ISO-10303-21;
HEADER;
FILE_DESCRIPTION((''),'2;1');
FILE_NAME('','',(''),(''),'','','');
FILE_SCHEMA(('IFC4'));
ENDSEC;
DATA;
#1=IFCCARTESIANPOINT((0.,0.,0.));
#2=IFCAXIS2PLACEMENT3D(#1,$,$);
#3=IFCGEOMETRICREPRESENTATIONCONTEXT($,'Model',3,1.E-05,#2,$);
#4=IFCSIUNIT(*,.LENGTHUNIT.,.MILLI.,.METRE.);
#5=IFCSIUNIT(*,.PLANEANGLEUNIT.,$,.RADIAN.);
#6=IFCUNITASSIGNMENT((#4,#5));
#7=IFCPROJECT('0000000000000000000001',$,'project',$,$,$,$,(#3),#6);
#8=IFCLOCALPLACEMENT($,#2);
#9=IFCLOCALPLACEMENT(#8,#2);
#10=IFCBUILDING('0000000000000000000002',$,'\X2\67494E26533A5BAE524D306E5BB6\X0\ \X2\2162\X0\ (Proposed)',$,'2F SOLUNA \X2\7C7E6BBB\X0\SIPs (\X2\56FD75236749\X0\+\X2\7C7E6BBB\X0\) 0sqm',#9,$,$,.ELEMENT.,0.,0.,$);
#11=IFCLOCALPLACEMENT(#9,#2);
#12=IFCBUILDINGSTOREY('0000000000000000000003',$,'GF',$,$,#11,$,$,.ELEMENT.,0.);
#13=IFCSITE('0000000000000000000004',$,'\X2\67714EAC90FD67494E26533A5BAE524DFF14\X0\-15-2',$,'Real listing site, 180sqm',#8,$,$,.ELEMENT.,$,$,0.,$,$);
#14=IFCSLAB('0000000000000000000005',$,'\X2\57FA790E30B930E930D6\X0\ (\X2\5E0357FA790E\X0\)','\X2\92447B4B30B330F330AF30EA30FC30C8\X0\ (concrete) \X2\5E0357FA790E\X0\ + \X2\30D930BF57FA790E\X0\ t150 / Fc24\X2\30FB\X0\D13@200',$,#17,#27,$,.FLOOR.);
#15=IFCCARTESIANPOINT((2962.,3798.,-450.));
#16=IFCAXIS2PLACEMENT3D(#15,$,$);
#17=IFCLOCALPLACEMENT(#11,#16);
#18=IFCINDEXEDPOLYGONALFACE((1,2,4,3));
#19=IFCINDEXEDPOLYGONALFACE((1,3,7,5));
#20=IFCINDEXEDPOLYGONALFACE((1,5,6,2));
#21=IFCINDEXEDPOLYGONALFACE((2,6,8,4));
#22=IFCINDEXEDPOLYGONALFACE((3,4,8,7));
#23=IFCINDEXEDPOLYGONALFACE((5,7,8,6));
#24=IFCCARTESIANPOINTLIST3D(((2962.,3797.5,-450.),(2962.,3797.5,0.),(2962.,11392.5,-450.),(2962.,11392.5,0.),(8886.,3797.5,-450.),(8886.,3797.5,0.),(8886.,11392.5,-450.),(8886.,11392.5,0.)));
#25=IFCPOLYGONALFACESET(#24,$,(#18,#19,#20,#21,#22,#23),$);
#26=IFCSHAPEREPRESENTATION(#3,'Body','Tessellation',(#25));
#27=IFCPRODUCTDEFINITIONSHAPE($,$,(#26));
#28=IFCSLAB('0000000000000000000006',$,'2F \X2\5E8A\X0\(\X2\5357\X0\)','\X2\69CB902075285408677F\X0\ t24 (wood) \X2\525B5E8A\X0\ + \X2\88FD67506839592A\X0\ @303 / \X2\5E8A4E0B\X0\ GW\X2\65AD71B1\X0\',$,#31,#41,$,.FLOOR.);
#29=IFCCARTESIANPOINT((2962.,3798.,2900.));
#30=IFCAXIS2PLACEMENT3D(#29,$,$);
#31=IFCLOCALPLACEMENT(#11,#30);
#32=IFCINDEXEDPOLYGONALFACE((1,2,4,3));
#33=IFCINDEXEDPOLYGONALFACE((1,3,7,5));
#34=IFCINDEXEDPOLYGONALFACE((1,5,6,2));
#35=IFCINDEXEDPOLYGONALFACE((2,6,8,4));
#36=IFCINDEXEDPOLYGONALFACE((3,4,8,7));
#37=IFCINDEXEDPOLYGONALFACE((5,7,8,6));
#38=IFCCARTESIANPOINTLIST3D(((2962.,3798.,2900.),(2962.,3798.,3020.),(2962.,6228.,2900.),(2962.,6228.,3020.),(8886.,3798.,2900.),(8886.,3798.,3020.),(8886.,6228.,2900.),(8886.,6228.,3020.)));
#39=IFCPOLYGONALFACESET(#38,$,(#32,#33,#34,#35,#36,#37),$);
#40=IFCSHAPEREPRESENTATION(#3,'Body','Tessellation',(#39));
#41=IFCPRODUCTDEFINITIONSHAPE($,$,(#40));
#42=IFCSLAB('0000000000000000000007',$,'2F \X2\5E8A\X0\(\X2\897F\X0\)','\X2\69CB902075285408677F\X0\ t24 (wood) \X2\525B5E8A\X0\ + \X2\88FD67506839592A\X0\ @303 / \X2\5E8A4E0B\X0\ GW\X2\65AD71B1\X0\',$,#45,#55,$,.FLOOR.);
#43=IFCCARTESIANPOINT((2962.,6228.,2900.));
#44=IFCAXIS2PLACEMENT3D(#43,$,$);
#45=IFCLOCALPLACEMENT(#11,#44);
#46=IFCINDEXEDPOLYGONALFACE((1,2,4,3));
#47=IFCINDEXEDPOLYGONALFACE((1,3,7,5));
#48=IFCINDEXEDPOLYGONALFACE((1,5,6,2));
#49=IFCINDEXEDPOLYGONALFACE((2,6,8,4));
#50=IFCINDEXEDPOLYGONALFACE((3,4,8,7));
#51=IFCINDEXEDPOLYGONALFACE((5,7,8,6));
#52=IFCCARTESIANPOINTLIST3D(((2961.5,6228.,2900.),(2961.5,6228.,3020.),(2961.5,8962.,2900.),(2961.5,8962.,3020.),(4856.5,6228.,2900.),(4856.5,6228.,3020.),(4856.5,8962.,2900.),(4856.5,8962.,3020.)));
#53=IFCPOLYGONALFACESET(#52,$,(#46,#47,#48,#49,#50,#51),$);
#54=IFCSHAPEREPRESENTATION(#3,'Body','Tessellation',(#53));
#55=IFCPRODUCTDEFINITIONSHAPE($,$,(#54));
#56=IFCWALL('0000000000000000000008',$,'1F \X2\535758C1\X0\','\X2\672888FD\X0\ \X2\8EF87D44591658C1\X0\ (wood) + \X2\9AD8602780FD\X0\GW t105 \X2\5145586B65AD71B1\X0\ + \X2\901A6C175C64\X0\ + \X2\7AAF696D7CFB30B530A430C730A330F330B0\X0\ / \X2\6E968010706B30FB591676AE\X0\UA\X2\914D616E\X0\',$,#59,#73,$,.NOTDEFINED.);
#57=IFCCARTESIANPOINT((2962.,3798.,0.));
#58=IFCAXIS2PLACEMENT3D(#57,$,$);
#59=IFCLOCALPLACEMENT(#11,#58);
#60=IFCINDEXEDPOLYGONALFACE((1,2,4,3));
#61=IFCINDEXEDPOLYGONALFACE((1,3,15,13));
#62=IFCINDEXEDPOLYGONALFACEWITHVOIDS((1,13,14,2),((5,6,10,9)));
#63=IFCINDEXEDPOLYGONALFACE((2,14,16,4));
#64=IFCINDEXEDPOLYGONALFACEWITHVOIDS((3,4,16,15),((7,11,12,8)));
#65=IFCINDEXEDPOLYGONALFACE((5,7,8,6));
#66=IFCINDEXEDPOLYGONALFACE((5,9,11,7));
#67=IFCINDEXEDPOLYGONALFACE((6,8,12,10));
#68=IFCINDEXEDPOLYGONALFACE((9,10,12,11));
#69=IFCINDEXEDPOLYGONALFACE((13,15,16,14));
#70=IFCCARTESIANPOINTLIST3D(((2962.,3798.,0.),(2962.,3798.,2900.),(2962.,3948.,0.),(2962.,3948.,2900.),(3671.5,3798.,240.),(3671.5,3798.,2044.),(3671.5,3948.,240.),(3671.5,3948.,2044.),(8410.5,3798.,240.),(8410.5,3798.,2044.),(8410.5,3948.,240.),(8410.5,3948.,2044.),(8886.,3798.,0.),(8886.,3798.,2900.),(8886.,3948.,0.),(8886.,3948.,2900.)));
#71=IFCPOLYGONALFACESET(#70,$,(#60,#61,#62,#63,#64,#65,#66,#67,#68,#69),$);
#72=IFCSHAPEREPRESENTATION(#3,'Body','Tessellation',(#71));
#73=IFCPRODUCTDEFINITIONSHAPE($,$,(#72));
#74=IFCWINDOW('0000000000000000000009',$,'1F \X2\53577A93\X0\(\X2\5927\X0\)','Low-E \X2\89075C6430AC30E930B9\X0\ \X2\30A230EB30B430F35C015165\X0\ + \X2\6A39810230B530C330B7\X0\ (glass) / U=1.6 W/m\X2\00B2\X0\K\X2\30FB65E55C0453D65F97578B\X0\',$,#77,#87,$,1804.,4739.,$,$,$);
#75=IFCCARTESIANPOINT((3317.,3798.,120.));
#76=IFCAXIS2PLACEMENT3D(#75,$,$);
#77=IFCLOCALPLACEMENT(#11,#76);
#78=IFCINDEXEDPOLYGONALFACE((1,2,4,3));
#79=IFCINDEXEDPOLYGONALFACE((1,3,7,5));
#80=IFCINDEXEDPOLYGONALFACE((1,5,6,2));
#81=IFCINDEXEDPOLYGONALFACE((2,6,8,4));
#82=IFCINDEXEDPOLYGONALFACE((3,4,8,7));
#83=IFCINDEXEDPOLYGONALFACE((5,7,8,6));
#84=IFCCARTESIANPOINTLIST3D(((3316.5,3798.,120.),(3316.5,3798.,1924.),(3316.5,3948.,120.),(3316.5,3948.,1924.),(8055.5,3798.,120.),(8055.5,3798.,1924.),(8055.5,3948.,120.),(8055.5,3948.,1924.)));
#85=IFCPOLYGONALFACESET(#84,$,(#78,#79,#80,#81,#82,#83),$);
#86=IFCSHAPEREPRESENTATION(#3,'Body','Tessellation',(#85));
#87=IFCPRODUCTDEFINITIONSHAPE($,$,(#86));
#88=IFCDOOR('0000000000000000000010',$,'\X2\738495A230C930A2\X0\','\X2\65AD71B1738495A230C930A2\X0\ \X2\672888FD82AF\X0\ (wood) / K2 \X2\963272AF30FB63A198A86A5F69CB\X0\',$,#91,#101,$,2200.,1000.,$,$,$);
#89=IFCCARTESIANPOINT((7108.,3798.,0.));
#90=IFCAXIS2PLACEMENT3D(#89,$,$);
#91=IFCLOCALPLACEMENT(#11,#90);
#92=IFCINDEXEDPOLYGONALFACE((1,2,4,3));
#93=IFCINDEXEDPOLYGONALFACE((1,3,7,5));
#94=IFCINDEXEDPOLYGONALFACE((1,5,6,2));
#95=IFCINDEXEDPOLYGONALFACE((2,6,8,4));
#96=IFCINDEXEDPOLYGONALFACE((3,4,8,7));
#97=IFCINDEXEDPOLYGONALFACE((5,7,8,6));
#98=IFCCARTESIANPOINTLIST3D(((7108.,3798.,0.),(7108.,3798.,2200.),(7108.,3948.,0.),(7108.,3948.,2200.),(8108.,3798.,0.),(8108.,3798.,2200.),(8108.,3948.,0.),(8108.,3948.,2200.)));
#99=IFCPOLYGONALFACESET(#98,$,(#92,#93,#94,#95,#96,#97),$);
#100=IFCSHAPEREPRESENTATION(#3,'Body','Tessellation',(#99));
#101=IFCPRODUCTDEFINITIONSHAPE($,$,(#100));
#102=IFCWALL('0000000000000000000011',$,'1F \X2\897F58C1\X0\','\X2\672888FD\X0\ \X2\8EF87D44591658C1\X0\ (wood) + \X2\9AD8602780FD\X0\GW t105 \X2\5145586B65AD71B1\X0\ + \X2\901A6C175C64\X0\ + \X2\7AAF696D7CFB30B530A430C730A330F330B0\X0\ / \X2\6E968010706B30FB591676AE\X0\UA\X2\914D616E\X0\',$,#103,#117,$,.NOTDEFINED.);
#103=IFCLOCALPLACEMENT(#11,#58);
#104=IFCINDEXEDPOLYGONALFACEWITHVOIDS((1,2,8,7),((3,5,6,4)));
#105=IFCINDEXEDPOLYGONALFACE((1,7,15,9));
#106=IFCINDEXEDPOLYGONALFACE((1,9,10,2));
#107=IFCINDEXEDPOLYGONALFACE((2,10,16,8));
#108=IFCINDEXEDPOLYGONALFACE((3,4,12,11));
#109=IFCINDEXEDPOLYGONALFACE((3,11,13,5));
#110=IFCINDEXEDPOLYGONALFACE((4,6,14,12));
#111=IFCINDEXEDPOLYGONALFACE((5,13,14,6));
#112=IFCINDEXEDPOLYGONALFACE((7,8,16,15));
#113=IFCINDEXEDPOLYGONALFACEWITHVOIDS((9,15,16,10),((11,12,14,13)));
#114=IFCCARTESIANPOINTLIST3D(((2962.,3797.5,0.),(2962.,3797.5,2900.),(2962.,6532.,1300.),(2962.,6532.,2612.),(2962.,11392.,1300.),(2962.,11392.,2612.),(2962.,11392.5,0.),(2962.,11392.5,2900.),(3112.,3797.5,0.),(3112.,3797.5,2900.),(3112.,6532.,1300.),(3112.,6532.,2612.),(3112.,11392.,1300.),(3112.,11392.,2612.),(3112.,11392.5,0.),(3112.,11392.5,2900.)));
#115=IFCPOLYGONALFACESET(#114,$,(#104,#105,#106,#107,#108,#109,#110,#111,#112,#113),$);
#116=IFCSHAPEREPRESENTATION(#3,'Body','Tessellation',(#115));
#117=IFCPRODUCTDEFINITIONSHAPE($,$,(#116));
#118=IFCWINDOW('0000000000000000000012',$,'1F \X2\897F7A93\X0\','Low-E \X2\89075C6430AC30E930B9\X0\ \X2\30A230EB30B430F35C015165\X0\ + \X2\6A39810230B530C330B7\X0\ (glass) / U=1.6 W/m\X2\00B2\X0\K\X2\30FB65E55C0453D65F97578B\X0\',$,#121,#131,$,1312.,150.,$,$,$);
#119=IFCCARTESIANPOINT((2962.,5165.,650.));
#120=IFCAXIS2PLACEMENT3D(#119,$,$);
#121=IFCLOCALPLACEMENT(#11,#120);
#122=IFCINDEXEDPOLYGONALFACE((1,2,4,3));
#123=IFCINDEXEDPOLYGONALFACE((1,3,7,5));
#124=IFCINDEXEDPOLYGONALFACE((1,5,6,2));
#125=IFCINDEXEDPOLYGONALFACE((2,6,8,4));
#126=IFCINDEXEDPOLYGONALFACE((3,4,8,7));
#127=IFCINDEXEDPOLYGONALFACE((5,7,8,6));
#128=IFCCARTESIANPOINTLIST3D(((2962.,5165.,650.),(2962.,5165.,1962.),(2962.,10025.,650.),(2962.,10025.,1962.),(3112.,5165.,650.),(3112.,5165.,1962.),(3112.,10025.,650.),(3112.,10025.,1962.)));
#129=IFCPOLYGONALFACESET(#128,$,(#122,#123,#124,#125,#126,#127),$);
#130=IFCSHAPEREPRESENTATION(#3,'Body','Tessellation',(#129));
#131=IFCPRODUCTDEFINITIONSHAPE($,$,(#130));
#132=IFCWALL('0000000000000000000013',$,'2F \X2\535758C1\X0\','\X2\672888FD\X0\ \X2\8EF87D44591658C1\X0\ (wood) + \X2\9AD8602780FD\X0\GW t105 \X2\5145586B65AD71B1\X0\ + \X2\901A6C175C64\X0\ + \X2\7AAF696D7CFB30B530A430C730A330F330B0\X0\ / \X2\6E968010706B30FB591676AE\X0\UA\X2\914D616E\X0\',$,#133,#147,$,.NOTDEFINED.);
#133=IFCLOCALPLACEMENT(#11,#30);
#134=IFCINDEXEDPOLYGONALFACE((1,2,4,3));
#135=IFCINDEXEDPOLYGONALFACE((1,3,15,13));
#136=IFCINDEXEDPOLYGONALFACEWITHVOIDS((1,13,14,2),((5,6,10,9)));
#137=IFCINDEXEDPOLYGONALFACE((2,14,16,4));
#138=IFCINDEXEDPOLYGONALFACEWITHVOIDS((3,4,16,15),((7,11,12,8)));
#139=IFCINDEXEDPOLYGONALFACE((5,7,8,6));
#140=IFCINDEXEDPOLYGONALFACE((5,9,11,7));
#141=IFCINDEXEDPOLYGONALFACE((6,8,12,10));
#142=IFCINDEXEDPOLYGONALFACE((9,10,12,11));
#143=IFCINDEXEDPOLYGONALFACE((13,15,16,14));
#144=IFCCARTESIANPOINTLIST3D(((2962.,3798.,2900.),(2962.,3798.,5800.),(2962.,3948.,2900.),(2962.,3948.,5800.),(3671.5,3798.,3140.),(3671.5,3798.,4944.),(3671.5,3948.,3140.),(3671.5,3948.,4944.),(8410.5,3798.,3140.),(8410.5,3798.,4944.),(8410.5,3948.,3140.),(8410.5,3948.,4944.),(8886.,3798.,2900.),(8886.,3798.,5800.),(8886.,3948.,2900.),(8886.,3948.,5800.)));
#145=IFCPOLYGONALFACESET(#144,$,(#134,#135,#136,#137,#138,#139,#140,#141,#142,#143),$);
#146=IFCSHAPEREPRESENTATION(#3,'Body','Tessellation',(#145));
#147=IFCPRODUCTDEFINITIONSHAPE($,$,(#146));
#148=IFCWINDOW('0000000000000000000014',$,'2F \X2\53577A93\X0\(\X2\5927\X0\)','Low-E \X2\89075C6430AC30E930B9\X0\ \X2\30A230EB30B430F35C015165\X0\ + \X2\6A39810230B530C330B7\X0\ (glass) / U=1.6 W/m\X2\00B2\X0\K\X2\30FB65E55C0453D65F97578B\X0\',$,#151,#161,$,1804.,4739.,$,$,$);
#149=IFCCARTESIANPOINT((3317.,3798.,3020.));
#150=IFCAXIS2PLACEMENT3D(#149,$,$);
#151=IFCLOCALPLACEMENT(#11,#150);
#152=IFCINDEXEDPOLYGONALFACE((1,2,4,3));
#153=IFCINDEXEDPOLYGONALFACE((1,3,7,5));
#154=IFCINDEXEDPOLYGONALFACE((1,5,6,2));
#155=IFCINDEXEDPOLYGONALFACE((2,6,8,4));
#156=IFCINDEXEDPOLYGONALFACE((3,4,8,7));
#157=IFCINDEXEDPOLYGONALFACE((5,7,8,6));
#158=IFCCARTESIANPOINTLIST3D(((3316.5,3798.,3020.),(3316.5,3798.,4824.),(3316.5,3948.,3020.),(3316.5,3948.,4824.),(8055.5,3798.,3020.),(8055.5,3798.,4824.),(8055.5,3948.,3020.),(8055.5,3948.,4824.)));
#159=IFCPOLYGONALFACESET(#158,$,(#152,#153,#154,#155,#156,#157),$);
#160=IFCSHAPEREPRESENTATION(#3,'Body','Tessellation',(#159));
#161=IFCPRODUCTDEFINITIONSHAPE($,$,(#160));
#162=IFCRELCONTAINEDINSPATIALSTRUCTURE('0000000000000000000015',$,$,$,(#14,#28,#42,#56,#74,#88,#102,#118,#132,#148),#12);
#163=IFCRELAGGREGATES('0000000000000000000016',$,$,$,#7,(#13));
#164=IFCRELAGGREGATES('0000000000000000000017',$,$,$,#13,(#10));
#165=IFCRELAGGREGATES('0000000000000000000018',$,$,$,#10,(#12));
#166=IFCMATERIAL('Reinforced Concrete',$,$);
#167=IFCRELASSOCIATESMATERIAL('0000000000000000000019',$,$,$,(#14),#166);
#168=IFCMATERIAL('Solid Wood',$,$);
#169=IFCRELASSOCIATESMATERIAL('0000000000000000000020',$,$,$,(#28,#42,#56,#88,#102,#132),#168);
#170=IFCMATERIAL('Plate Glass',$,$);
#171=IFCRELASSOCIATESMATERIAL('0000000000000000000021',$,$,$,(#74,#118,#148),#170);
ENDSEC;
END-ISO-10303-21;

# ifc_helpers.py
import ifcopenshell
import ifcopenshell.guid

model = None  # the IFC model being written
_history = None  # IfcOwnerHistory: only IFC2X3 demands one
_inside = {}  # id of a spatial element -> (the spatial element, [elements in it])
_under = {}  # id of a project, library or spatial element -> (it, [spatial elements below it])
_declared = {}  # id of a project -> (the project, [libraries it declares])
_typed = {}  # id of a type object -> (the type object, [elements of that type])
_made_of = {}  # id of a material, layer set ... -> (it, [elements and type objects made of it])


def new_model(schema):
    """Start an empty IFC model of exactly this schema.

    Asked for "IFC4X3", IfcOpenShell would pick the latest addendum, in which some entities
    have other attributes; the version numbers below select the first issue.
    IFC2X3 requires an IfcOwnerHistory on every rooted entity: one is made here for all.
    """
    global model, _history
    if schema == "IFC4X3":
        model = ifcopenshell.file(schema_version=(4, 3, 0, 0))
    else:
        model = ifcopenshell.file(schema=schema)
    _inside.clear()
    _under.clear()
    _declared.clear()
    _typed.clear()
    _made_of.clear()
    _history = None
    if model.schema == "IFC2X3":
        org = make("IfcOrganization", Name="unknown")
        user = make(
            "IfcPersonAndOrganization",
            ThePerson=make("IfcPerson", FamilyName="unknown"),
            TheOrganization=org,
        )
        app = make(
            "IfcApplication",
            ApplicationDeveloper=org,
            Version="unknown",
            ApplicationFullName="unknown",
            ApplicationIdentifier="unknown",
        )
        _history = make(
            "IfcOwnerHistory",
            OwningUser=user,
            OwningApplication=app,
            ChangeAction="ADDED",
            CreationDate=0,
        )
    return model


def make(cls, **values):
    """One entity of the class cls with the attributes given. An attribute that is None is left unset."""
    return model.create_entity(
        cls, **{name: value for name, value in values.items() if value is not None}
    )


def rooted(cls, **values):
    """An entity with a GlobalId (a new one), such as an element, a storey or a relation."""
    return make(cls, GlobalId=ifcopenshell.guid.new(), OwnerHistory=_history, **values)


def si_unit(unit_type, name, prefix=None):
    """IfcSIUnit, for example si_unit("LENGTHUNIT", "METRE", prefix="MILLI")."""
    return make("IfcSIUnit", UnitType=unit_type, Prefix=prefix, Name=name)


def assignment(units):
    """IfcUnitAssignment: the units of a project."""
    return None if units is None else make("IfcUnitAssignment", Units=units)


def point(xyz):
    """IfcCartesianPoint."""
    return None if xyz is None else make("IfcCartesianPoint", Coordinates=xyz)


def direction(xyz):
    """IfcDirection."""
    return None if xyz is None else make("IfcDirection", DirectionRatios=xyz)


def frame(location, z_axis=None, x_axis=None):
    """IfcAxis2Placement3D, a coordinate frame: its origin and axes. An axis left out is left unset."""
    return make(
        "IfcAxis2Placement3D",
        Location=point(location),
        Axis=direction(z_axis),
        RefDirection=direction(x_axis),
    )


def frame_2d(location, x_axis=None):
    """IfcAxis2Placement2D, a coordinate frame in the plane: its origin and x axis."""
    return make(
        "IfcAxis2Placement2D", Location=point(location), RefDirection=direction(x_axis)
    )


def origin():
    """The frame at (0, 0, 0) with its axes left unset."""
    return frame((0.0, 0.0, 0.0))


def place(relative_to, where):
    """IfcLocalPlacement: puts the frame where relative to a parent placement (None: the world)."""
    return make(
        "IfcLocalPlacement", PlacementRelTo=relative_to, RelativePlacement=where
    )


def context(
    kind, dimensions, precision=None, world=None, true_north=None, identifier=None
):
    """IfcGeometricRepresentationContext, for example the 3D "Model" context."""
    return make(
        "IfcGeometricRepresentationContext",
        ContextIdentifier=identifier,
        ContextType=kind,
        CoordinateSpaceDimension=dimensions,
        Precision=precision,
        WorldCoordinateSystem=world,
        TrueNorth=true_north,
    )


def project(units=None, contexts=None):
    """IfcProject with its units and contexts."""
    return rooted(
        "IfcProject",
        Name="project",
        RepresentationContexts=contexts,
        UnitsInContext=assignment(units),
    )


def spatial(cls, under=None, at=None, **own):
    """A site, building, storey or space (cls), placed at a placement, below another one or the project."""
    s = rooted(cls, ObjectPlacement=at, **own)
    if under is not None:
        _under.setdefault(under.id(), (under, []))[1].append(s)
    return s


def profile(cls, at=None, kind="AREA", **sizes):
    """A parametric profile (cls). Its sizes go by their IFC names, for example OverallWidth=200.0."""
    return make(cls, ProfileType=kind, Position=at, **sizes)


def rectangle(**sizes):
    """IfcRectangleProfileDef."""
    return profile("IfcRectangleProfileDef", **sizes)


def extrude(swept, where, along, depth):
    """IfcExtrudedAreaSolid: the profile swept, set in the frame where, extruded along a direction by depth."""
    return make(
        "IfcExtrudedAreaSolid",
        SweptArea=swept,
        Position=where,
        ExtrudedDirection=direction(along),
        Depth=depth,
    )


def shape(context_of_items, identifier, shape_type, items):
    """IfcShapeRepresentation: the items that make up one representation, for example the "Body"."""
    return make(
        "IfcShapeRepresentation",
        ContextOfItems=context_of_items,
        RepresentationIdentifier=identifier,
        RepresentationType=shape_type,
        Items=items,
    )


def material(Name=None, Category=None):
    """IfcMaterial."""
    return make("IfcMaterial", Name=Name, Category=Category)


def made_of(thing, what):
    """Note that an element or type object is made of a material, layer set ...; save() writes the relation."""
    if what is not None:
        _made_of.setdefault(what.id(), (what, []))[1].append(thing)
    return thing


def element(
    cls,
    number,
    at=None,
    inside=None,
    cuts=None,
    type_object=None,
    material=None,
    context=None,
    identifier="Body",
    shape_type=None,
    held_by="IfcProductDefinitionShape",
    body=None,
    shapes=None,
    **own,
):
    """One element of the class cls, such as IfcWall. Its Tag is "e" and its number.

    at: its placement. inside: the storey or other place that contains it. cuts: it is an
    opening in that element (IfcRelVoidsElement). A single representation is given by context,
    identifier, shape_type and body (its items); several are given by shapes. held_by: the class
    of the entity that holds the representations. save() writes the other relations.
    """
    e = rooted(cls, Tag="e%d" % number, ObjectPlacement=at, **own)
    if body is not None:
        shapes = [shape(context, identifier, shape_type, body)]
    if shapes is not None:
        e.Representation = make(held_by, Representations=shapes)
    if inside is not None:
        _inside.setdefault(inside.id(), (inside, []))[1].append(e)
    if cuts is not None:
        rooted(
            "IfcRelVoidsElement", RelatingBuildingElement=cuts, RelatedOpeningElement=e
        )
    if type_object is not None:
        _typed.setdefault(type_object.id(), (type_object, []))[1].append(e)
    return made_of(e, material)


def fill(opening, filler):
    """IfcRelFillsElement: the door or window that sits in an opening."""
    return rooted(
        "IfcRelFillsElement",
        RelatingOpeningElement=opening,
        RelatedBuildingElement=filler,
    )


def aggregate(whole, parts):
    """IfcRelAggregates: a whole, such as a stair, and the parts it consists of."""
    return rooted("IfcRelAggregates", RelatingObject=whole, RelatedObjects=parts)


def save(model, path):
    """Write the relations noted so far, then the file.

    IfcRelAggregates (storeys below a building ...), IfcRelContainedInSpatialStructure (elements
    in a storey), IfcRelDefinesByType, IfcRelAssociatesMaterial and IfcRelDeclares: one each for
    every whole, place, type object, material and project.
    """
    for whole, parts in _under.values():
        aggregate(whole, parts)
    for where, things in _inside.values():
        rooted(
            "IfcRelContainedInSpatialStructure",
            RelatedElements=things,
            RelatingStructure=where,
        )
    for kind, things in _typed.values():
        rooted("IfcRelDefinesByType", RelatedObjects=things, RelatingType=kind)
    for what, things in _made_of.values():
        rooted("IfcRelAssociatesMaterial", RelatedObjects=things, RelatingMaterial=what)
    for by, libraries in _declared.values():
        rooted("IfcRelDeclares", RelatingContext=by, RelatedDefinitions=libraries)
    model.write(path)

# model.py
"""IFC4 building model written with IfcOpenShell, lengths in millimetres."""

from ifc_helpers import new_model, si_unit, frame, frame_2d, origin, place, context, project, spatial, rectangle, extrude, material, element, fill, save


model = new_model("IFC4")

# Units and contexts
model_context = context("Model", 3, precision=1e-05, world=origin())
ifc_project = project(units=[si_unit("LENGTHUNIT", "METRE", prefix="MILLI"), si_unit("PLANEANGLEUNIT", "RADIAN")], contexts=[model_context])

# Site, building, storey
site_placement = place(None, origin())
site = spatial("IfcSite", under=ifc_project, at=site_placement, Name="東京都杉並区宮前４-15-2", ObjectType="Real listing site, 180sqm", CompositionType="ELEMENT", RefElevation=0.0)
building_placement = place(site_placement, origin())
building = spatial("IfcBuilding", under=site, at=building_placement, Name="杉並区宮前の家 Ⅲ (Proposed)", ObjectType="2F SOLUNA 籾殻SIPs (国産杉+籾殻) 0sqm", CompositionType="ELEMENT", ElevationOfRefHeight=0.0, ElevationOfTerrain=0.0)
storey_placement = place(building_placement, origin())
storey = spatial("IfcBuildingStorey", under=building, at=storey_placement, Name="GF", CompositionType="ELEMENT", Elevation=0.0)

# Slabs
ifc_material_1 = material(Name="Reinforced Concrete")
slab_1_placement = place(storey_placement, frame((2962.0, 3798.0, -450.0)))
element("IfcSlab", 1, at=slab_1_placement, inside=storey, material=ifc_material_1, Name="基礎スラブ (布基礎)", Description="鉄筋コンクリート (concrete) 布基礎 + ベタ基礎 t150 / Fc24・D13@200", PredefinedType="FLOOR", context=model_context, shape_type="SweptSolid", body=[
    extrude(rectangle(XDim=5924.0, YDim=7595.0, at=frame_2d((2962.0, 3797.0))), frame((2962.0, 3798.0, -450.0)), (0.0, 0.0, 1.0), 450.0),
])
ifc_material_2 = material(Name="Solid Wood")
slab_2_placement = place(storey_placement, frame((2962.0, 3798.0, 2900.0)))
element("IfcSlab", 2, at=slab_2_placement, inside=storey, material=ifc_material_2, Name="2F 床(南)", Description="構造用合板 t24 (wood) 剛床 + 製材根太 @303 / 床下 GW断熱", PredefinedType="FLOOR", context=model_context, shape_type="SweptSolid", body=[
    extrude(rectangle(XDim=5924.0, YDim=2430.0, at=frame_2d((2962.0, 1215.0))), frame((2962.0, 3798.0, 2900.0)), (0.0, 0.0, 1.0), 120.0),
])
slab_3_placement = place(storey_placement, frame((2962.0, 6228.0, 2900.0)))
element("IfcSlab", 3, at=slab_3_placement, inside=storey, material=ifc_material_2, Name="2F 床(西)", Description="構造用合板 t24 (wood) 剛床 + 製材根太 @303 / 床下 GW断熱", PredefinedType="FLOOR", context=model_context, shape_type="SweptSolid", body=[
    extrude(rectangle(XDim=1895.0, YDim=2734.0, at=frame_2d((947.0, 1367.0))), frame((2962.0, 6228.0, 2900.0)), (0.0, 0.0, 1.0), 120.0),
])

# Wall, openings, window, door
wall_1_placement = place(storey_placement, frame((2962.0, 3798.0, 0.0)))
wall_1 = element("IfcWall", 4, at=wall_1_placement, inside=storey, material=ifc_material_2, Name="1F 南壁", Description="木製 軸組外壁 (wood) + 高性能GW t105 充填断熱 + 通気層 + 窯業系サイディング / 準耐火・外皮UA配慮", PredefinedType="NOTDEFINED", context=model_context, shape_type="SweptSolid", body=[
    extrude(rectangle(XDim=5924.0, YDim=150.0, at=frame_2d((2962.0, 75.0))), frame((2962.0, 3798.0, 0.0)), (0.0, 0.0, 1.0), 2900.0),
])
opening_1_placement = place(storey_placement, frame((3317.0, 3798.0, 120.0)))
opening_1 = element("IfcOpeningElement", 5, at=opening_1_placement, cuts=wall_1, PredefinedType="NOTDEFINED", context=model_context, shape_type="SweptSolid", body=[
    extrude(rectangle(XDim=4739.0, YDim=150.0, at=frame_2d((2369.0, 75.0))), frame((3317.0, 3798.0, 120.0)), (0.0, 0.0, 1.0), 1804.0),
])
opening_2_placement = place(storey_placement, frame((7108.0, 3798.0, 0.0)))
opening_2 = element("IfcOpeningElement", 6, at=opening_2_placement, cuts=wall_1, PredefinedType="NOTDEFINED", context=model_context, shape_type="SweptSolid", body=[
    extrude(rectangle(XDim=1000.0, YDim=150.0, at=frame_2d((500.0, 75.0))), frame((7108.0, 3798.0, 0.0)), (0.0, 0.0, 1.0), 2200.0),
])
ifc_material_3 = material(Name="Plate Glass")
window_1_placement = place(storey_placement, frame((3317.0, 3798.0, 120.0)))
window_1 = element("IfcWindow", 7, at=window_1_placement, inside=storey, material=ifc_material_3, Name="1F 南窓(大)", Description="Low-E 複層ガラス アルゴン封入 + 樹脂サッシ (glass) / U=1.6 W/m²K・日射取得型", OverallHeight=1804.0, OverallWidth=4739.0, context=model_context, shape_type="SweptSolid", body=[
    extrude(rectangle(XDim=4739.0, YDim=150.0, at=frame_2d((2369.0, 75.0))), frame((3317.0, 3798.0, 120.0)), (0.0, 0.0, 1.0), 1804.0),
])
fill(opening_1, window_1)
door_placement = place(storey_placement, frame((7108.0, 3798.0, 0.0)))
door = element("IfcDoor", 8, at=door_placement, inside=storey, material=ifc_material_2, Name="玄関ドア", Description="断熱玄関ドア 木製芯 (wood) / K2 防犯・採風機構", OverallHeight=2200.0, OverallWidth=1000.0, context=model_context, shape_type="SweptSolid", body=[
    extrude(rectangle(XDim=1000.0, YDim=150.0, at=frame_2d((500.0, 75.0))), frame((7108.0, 3798.0, 0.0)), (0.0, 0.0, 1.0), 2200.0),
])
fill(opening_2, door)

# Walls, openings, windows
wall_2_placement = place(storey_placement, frame((2962.0, 3798.0, 0.0)))
wall_2 = element("IfcWall", 9, at=wall_2_placement, inside=storey, material=ifc_material_2, Name="1F 西壁", Description="木製 軸組外壁 (wood) + 高性能GW t105 充填断熱 + 通気層 + 窯業系サイディング / 準耐火・外皮UA配慮", PredefinedType="NOTDEFINED", context=model_context, shape_type="SweptSolid", body=[
    extrude(rectangle(XDim=150.0, YDim=7595.0, at=frame_2d((75.0, 3797.0))), frame((2962.0, 3798.0, 0.0)), (0.0, 0.0, 1.0), 2900.0),
])
opening_3_placement = place(storey_placement, frame((2962.0, 5165.0, 650.0)))
opening_3 = element("IfcOpeningElement", 10, at=opening_3_placement, cuts=wall_2, PredefinedType="NOTDEFINED", context=model_context, shape_type="SweptSolid", body=[
    extrude(rectangle(XDim=150.0, YDim=4860.0, at=frame_2d((75.0, 2430.0))), frame((2962.0, 5165.0, 650.0)), (0.0, 0.0, 1.0), 1312.0),
])
window_2_placement = place(storey_placement, frame((2962.0, 5165.0, 650.0)))
window_2 = element("IfcWindow", 11, at=window_2_placement, inside=storey, material=ifc_material_3, Name="1F 西窓", Description="Low-E 複層ガラス アルゴン封入 + 樹脂サッシ (glass) / U=1.6 W/m²K・日射取得型", OverallHeight=1312.0, OverallWidth=150.0, context=model_context, shape_type="SweptSolid", body=[
    extrude(rectangle(XDim=150.0, YDim=4860.0, at=frame_2d((75.0, 2430.0))), frame((2962.0, 5165.0, 650.0)), (0.0, 0.0, 1.0), 1312.0),
])
fill(opening_3, window_2)
wall_3_placement = place(storey_placement, frame((2962.0, 3798.0, 2900.0)))
wall_3 = element("IfcWall", 12, at=wall_3_placement, inside=storey, material=ifc_material_2, Name="2F 南壁", Description="木製 軸組外壁 (wood) + 高性能GW t105 充填断熱 + 通気層 + 窯業系サイディング / 準耐火・外皮UA配慮", PredefinedType="NOTDEFINED", context=model_context, shape_type="SweptSolid", body=[
    extrude(rectangle(XDim=5924.0, YDim=150.0, at=frame_2d((2962.0, 75.0))), frame((2962.0, 3798.0, 2900.0)), (0.0, 0.0, 1.0), 2900.0),
])
opening_4_placement = place(storey_placement, frame((3317.0, 3798.0, 3020.0)))
opening_4 = element("IfcOpeningElement", 13, at=opening_4_placement, cuts=wall_3, PredefinedType="NOTDEFINED", context=model_context, shape_type="SweptSolid", body=[
    extrude(rectangle(XDim=4739.0, YDim=150.0, at=frame_2d((2369.0, 75.0))), frame((3317.0, 3798.0, 3020.0)), (0.0, 0.0, 1.0), 1804.0),
])
window_3_placement = place(storey_placement, frame((3317.0, 3798.0, 3020.0)))
window_3 = element("IfcWindow", 14, at=window_3_placement, inside=storey, material=ifc_material_3, Name="2F 南窓(大)", Description="Low-E 複層ガラス アルゴン封入 + 樹脂サッシ (glass) / U=1.6 W/m²K・日射取得型", OverallHeight=1804.0, OverallWidth=4739.0, context=model_context, shape_type="SweptSolid", body=[
    extrude(rectangle(XDim=4739.0, YDim=150.0, at=frame_2d((2369.0, 75.0))), frame((3317.0, 3798.0, 3020.0)), (0.0, 0.0, 1.0), 1804.0),
])
fill(opening_4, window_3)

save(model, "model.ifc")
